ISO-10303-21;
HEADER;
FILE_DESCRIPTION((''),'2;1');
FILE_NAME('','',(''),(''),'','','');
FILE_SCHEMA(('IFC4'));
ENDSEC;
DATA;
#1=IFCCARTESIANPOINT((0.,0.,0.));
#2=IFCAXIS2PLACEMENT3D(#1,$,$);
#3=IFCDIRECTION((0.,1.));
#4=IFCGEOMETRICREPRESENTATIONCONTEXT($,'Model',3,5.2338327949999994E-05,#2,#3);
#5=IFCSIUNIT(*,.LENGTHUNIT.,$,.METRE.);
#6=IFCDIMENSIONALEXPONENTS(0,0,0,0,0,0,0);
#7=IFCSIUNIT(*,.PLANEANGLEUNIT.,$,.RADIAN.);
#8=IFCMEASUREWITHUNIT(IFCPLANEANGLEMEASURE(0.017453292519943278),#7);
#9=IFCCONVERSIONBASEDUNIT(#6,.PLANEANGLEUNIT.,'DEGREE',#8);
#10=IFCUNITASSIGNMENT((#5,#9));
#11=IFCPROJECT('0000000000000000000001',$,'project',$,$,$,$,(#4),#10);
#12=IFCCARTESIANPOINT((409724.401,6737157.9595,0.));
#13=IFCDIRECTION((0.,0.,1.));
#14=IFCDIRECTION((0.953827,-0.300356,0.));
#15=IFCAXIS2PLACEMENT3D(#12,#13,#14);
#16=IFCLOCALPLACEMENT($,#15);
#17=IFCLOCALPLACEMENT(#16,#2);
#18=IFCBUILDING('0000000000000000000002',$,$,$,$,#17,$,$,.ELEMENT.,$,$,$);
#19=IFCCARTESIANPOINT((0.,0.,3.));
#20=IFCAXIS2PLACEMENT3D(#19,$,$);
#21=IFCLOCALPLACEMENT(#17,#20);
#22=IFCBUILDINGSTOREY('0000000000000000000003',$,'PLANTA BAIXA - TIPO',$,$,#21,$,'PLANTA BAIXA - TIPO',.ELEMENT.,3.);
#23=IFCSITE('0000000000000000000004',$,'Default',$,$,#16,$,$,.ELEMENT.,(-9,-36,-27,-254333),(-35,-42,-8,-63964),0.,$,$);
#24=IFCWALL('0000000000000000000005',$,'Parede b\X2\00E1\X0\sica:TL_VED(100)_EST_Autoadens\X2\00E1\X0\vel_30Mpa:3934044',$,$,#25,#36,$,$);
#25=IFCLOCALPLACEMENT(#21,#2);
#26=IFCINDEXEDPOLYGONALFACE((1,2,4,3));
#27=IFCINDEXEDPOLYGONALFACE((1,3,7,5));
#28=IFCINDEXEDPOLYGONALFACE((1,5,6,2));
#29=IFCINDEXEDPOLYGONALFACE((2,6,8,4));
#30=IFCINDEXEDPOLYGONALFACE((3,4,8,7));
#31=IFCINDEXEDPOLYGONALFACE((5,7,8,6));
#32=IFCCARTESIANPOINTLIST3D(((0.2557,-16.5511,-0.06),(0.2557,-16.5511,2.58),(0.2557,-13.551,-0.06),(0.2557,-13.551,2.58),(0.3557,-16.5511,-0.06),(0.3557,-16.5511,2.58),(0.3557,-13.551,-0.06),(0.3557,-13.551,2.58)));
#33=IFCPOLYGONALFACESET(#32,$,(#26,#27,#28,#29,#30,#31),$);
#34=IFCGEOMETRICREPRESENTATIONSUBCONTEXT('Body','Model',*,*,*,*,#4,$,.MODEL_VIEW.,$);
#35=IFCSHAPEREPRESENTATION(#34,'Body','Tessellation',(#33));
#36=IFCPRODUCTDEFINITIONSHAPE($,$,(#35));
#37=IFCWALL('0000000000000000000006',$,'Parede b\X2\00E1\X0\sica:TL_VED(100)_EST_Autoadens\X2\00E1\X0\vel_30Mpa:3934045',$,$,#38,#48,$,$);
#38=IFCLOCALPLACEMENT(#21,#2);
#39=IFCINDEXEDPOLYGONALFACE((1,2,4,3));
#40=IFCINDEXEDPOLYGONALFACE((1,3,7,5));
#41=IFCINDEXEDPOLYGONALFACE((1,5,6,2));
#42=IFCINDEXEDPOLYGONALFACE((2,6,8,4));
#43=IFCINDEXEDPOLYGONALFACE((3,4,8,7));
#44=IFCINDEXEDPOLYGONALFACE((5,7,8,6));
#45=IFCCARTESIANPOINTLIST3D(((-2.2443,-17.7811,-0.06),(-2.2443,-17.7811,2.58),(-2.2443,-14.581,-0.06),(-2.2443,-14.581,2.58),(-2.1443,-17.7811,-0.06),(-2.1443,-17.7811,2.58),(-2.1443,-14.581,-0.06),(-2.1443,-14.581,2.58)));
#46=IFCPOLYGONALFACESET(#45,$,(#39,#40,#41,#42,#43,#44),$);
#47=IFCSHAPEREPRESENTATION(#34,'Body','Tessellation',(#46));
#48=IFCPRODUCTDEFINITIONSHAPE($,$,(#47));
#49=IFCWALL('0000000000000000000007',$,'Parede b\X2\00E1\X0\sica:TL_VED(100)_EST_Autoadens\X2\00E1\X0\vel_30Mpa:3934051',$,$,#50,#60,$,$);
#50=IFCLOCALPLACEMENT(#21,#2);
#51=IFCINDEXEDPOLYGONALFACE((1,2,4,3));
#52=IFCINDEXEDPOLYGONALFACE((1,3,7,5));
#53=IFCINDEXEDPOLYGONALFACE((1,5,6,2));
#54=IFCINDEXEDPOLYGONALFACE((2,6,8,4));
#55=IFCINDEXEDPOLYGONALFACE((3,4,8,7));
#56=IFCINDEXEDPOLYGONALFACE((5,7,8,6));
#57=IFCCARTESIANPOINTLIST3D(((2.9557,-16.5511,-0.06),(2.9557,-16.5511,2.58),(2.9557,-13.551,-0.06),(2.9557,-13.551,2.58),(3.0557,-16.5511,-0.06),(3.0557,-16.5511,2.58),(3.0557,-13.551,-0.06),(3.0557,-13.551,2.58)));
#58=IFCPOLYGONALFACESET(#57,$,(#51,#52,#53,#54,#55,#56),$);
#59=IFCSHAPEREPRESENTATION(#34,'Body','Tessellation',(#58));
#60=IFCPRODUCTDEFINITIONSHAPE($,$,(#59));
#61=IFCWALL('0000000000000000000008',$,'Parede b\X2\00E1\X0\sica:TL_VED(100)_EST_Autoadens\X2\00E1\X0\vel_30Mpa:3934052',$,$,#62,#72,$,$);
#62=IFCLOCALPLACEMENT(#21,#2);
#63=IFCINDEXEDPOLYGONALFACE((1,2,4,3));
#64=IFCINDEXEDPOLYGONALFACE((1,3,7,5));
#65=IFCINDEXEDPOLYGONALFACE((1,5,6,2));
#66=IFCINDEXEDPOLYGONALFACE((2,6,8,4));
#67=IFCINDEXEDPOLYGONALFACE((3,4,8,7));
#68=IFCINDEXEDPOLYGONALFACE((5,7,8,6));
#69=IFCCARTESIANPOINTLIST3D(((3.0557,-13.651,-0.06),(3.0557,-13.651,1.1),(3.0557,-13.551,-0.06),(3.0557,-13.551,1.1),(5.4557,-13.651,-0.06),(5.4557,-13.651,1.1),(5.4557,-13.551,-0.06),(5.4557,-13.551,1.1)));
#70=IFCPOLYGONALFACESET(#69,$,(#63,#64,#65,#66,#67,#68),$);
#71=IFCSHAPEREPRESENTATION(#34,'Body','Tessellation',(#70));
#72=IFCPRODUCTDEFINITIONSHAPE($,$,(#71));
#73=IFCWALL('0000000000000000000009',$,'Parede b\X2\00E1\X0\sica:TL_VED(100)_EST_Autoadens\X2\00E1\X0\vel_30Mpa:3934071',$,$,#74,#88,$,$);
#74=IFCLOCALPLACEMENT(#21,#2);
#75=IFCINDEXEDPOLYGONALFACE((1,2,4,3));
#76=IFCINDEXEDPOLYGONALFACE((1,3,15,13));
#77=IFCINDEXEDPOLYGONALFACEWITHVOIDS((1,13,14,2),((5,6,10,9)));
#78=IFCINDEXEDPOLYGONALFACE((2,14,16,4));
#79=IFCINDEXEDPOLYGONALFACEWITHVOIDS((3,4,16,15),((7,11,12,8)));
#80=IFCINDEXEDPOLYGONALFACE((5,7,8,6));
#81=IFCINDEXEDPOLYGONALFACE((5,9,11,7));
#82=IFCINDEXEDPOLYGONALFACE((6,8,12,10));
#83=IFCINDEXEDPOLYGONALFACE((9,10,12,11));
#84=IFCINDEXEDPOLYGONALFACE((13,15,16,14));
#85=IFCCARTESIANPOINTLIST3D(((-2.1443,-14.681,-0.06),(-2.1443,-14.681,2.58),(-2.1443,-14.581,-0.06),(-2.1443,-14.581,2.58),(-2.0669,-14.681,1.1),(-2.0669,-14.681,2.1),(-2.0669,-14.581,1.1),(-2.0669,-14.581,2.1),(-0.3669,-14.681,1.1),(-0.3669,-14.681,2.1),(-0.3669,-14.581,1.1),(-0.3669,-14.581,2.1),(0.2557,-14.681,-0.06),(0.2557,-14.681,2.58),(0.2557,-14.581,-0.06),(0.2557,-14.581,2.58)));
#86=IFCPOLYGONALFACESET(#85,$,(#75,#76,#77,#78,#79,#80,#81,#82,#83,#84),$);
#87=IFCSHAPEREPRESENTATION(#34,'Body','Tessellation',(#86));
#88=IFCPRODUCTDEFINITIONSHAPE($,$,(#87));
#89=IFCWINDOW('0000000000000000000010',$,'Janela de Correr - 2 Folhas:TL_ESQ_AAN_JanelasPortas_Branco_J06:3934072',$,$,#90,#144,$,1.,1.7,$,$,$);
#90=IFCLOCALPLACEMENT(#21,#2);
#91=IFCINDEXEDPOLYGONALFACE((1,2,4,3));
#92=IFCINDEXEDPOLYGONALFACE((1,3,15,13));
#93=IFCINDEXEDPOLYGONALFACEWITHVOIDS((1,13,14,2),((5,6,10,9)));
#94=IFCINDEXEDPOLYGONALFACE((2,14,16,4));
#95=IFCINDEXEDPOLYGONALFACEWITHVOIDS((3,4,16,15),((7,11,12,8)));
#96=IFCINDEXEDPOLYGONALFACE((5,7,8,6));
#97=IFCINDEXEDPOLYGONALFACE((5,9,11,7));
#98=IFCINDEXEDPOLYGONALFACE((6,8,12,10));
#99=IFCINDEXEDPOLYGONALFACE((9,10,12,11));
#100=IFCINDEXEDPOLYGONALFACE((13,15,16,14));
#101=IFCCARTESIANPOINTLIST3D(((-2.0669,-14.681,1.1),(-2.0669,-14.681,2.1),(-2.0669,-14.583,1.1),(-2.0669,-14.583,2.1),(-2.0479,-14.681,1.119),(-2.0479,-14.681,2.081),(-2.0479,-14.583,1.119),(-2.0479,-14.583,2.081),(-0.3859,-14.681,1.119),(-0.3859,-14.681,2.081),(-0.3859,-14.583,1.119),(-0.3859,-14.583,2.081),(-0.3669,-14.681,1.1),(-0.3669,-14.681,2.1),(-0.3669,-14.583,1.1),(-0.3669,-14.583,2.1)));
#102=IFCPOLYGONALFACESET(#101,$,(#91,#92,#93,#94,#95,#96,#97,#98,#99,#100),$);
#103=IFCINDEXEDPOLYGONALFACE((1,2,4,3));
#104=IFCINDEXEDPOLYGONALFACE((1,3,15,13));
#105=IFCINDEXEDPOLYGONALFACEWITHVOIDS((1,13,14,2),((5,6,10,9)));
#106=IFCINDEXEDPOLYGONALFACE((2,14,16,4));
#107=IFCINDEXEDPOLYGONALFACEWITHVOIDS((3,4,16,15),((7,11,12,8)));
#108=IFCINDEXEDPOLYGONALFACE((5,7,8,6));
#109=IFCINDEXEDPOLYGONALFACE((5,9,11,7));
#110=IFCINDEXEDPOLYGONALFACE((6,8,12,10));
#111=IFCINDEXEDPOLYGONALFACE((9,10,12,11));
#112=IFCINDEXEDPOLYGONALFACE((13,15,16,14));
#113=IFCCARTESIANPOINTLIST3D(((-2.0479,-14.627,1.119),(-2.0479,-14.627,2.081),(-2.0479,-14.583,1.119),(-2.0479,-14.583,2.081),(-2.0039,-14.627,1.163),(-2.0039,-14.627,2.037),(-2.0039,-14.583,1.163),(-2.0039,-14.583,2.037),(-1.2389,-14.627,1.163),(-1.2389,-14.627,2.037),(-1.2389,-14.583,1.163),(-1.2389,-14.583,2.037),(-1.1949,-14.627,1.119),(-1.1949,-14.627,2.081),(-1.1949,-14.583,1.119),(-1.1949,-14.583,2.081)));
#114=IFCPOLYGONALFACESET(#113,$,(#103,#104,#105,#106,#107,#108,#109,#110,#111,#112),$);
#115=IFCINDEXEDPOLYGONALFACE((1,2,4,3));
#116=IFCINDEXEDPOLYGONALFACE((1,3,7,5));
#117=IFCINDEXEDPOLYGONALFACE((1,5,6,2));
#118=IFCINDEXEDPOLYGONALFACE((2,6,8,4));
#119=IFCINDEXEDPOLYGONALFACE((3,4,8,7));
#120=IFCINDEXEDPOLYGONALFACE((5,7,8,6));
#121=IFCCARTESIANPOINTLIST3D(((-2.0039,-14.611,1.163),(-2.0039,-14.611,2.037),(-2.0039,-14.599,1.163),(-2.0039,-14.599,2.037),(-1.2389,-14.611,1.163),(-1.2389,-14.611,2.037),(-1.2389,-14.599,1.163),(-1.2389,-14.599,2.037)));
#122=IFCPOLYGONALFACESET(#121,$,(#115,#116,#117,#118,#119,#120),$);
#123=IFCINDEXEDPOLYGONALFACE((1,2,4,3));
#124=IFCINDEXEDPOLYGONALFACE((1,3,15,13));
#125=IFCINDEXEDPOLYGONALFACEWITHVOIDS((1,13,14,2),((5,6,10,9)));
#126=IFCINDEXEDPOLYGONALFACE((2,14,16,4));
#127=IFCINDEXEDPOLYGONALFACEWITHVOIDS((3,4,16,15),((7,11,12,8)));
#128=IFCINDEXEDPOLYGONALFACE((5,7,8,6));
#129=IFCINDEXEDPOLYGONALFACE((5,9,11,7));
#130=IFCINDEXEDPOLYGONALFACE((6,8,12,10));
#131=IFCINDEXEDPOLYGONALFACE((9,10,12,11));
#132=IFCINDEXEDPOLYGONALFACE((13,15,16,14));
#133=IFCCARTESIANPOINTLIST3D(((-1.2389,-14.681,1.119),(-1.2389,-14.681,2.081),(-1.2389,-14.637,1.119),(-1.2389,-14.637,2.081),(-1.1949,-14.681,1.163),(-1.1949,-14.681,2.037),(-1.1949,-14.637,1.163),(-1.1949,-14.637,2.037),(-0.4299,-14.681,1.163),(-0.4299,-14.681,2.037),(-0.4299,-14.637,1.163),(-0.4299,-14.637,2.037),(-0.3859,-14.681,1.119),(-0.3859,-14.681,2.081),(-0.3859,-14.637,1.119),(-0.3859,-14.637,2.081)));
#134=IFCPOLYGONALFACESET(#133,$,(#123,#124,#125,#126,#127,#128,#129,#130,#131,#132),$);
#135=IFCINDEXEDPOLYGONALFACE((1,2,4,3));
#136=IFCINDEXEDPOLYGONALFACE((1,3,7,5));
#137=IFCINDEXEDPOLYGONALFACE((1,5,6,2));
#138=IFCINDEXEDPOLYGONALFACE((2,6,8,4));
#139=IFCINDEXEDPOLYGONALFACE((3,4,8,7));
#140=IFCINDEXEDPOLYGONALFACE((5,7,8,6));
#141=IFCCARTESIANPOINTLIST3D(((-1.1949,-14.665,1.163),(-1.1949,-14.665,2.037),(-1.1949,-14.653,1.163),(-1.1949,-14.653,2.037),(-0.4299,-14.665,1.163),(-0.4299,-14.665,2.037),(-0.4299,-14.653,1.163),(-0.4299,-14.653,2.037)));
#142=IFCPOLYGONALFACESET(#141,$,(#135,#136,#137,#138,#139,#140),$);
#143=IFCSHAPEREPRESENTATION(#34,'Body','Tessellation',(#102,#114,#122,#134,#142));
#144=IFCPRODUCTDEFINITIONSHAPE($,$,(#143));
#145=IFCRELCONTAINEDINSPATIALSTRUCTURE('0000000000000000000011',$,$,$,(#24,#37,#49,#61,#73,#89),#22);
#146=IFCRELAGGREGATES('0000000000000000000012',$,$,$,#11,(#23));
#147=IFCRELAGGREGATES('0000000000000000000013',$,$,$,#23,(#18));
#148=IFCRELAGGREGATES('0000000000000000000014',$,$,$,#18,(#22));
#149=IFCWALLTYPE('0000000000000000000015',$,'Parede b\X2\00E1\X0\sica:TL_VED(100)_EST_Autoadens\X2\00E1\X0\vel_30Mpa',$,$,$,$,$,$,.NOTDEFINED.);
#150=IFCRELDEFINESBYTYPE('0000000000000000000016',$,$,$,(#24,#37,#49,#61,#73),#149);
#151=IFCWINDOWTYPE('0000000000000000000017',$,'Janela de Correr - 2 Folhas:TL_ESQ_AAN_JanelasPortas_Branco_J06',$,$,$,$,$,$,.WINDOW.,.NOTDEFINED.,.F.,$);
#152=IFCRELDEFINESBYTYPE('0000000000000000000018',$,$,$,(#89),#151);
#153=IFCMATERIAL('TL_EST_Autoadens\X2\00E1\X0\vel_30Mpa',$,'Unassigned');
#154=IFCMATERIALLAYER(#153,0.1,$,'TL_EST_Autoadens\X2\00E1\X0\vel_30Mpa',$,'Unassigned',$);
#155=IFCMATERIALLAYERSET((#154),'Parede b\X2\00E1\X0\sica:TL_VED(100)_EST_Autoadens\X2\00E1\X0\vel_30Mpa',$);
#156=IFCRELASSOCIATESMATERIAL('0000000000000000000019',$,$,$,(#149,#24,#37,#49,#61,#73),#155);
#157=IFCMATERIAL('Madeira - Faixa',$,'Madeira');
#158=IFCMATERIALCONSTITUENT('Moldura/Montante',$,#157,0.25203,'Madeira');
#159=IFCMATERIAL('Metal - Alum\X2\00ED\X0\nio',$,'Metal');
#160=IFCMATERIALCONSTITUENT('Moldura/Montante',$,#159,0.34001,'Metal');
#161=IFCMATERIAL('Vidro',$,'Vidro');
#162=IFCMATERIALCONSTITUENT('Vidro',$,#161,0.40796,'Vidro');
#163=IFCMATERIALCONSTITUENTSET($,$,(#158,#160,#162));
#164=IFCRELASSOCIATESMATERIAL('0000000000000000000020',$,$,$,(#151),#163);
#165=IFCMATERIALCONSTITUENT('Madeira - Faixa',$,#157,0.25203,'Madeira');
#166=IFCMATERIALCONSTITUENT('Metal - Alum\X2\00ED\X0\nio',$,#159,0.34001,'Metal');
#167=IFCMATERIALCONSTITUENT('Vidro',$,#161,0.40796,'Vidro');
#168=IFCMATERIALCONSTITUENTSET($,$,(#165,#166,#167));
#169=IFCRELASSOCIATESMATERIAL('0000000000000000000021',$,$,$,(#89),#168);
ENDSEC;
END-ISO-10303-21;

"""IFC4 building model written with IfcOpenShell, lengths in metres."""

from ifc_helpers import new_model, entity, si_unit, converted_unit, direction, frame, frame_2d, origin, origin_2d_with_axis, place, context, subcontext, project, spatial, polyline, rectangle, outline, extrude, source, transform, mapped, material, layer, layer_set, layer_usage, constituent, constituent_set, type_object, type_shapes, element, fill, save


model = new_model("IFC4")

# Units and contexts
model_context = context("Model", 3, precision=5.2338327949999994e-05, world=origin(), true_north=direction((0.0, 1.0)))
body_context = subcontext(model_context, "Body", "Model", "MODEL_VIEW")
ifc_project = project(units=[si_unit("LENGTHUNIT", "METRE"), converted_unit("PLANEANGLEUNIT", "DEGREE", entity("IfcPlaneAngleMeasure", 0.017453292519943278), si_unit("PLANEANGLEUNIT", "RADIAN"), dimensions=[0, 0, 0, 0, 0, 0, 0])], contexts=[model_context])

# Site, building, storey
site_placement = place(None, frame((409724.401, 6737157.9595, 0.0), z_axis=(0.0, 0.0, 1.0), x_axis=(0.953827, -0.300356, 0.0)))
site = spatial("IfcSite", under=ifc_project, at=site_placement, Name="Default", CompositionType="ELEMENT", RefLatitude=(-9, -36, -27, -254333), RefLongitude=(-35, -42, -8, -63964), RefElevation=0.0)
building_placement = place(site_placement, origin())
building = spatial("IfcBuilding", under=site, at=building_placement, CompositionType="ELEMENT")
storey_placement = place(building_placement, frame((0.0, 0.0, 3.0)))
storey = spatial("IfcBuildingStorey", under=building, at=storey_placement, Name="PLANTA BAIXA - TIPO", LongName="PLANTA BAIXA - TIPO", CompositionType="ELEMENT", Elevation=3.0)

# Walls
ifc_material_1 = material(Name="TL_EST_Autoadensável_30Mpa", Category="Unassigned")
ifc_layer_1 = layer(ifc_material_1, 0.1, Name="TL_EST_Autoadensável_30Mpa", Category="Unassigned")
ifc_layer_set_1 = layer_set([ifc_layer_1], Name="Parede básica:TL_VED(100)_EST_Autoadensável_30Mpa")
ifc_layer_usage_1 = layer_usage(ifc_layer_set_1, "AXIS2", "NEGATIVE", 0.05)
wall_type_1 = type_object("IfcWallType", Name="Parede básica:TL_VED(100)_EST_Autoadensável_30Mpa", PredefinedType="NOTDEFINED", material=ifc_layer_set_1)
wall_1_placement = place(storey_placement, frame((0.3057, -13.551, -0.06), z_axis=(0.0, 0.0, 1.0), x_axis=(0.0, -1.0, 0.0)))
element("IfcWall", 1, at=wall_1_placement, inside=storey, type_object=wall_type_1, material=ifc_layer_usage_1, Name="Parede básica:TL_VED(100)_EST_Autoadensável_30Mpa:3934044", context=body_context, shape_type="SweptSolid", body=[
    extrude(rectangle(XDim=3.0001, YDim=0.1, at=frame_2d((1.5001, 0.0), x_axis=(-1.0, 0.0))), origin(), (0.0, 0.0, 1.0), 2.64),
])
ifc_layer_usage_2 = layer_usage(ifc_layer_set_1, "AXIS2", "NEGATIVE", 0.05)
wall_2_placement = place(storey_placement, frame((-2.1943, -14.581, -0.06), z_axis=(0.0, 0.0, 1.0), x_axis=(0.0, -1.0, 0.0)))
element("IfcWall", 2, at=wall_2_placement, inside=storey, type_object=wall_type_1, material=ifc_layer_usage_2, Name="Parede básica:TL_VED(100)_EST_Autoadensável_30Mpa:3934045", context=body_context, shape_type="SweptSolid", body=[
    extrude(rectangle(XDim=3.2001, YDim=0.1, at=frame_2d((1.6001, 0.0), x_axis=(-1.0, 0.0))), origin(), (0.0, 0.0, 1.0), 2.64),
])

# Wall, opening
ifc_layer_usage_3 = layer_usage(ifc_layer_set_1, "AXIS2", "NEGATIVE", 0.05)
wall_3_placement = place(storey_placement, frame((3.0057, -13.551, -0.06), z_axis=(0.0, 0.0, 1.0), x_axis=(0.0, -1.0, 0.0)))
wall_3 = element("IfcWall", 3, at=wall_3_placement, inside=storey, type_object=wall_type_1, material=ifc_layer_usage_3, Name="Parede básica:TL_VED(100)_EST_Autoadensável_30Mpa:3934051", context=body_context, shape_type="SweptSolid", body=[
    extrude(rectangle(XDim=3.0001, YDim=0.1, at=frame_2d((1.5001, 0.0), x_axis=(-1.0, 0.0))), origin(), (0.0, 0.0, 1.0), 2.64),
])
opening_1_placement = place(wall_3_placement, frame((-13.551, -3.0057, 0.06)))
element("IfcOpeningElement", 4, at=opening_1_placement, cuts=wall_3, PredefinedType="OPENING", context=body_context, shape_type="SweptSolid", body=[
    extrude(rectangle(XDim=2.1, YDim=0.1, at=frame_2d((0.0, 0.0), x_axis=(0.0, 1.0))), frame((14.501, 3.0557, 1.05), z_axis=(0.0, 1.0, 0.0), x_axis=(1.0, 0.0, 0.0)), (0.0, 0.0, 1.0), 2.4),
])

# Wall
ifc_layer_usage_4 = layer_usage(ifc_layer_set_1, "AXIS2", "NEGATIVE", 0.05)
wall_4_placement = place(storey_placement, frame((3.0557, -13.601, -0.06)))
element("IfcWall", 5, at=wall_4_placement, inside=storey, type_object=wall_type_1, material=ifc_layer_usage_4, Name="Parede básica:TL_VED(100)_EST_Autoadensável_30Mpa:3934052", context=body_context, shape_type="SweptSolid", body=[
    extrude(rectangle(XDim=2.4, YDim=0.1, at=frame_2d((1.2, 0.0), x_axis=(-1.0, 0.0))), origin(), (0.0, 0.0, 1.0), 1.16),
])

# Wall, opening, window
ifc_layer_usage_5 = layer_usage(ifc_layer_set_1, "AXIS2", "NEGATIVE", 0.05)
wall_5_placement = place(storey_placement, frame((-2.1443, -14.631, -0.06)))
wall_5 = element("IfcWall", 6, at=wall_5_placement, inside=storey, type_object=wall_type_1, material=ifc_layer_usage_5, Name="Parede básica:TL_VED(100)_EST_Autoadensável_30Mpa:3934071", context=body_context, shape_type="SweptSolid", body=[
    extrude(rectangle(XDim=2.4, YDim=0.1, at=frame_2d((1.2, 0.0), x_axis=(-1.0, 0.0))), origin(), (0.0, 0.0, 1.0), 2.64),
])
opening_2_placement = place(wall_5_placement, frame((0.0774, -0.05, 1.16)))
opening_2 = element("IfcOpeningElement", 7, at=opening_2_placement, cuts=wall_5, PredefinedType="OPENING", context=body_context, shape_type="SweptSolid", body=[
    extrude(rectangle(XDim=1.0, YDim=1.7, at=frame_2d((0.5, 0.85), x_axis=(-1.0, 0.0))), frame((0.0, 0.0, 0.0), z_axis=(0.0, 1.0, 0.0), x_axis=(0.0, 0.0, 1.0)), (0.0, 0.0, 1.0), 0.1),
])
ifc_material_2 = material(Name="Madeira - Faixa", Category="Madeira")
ifc_constituent_1 = constituent(ifc_material_2, Name="Madeira - Faixa", Category="Madeira", fraction=0.25203)
ifc_material_3 = material(Name="Metal - Alumínio", Category="Metal")
ifc_constituent_2 = constituent(ifc_material_3, Name="Metal - Alumínio", Category="Metal", fraction=0.34001)
ifc_material_4 = material(Name="Vidro", Category="Vidro")
ifc_constituent_3 = constituent(ifc_material_4, Name="Vidro", Category="Vidro", fraction=0.40796)
ifc_constituent_set_1 = constituent_set(constituents=[ifc_constituent_1, ifc_constituent_2, ifc_constituent_3])
ifc_constituent_4 = constituent(ifc_material_2, Name="Moldura/Montante", Category="Madeira", fraction=0.25203)
ifc_constituent_5 = constituent(ifc_material_3, Name="Moldura/Montante", Category="Metal", fraction=0.34001)
ifc_constituent_6 = constituent(ifc_material_4, Name="Vidro", Category="Vidro", fraction=0.40796)
ifc_constituent_set_2 = constituent_set(constituents=[ifc_constituent_4, ifc_constituent_5, ifc_constituent_6])
window_type_1 = type_object("IfcWindowType", Name="Janela de Correr - 2 Folhas:TL_ESQ_AAN_JanelasPortas_Branco_J06", ParameterTakesPrecedence=False, PartitioningType="NOTDEFINED", PredefinedType="WINDOW", material=ifc_constituent_set_2)
shared_shape_1 = source(origin(), body_context, "Body", "SweptSolid", [
    extrude(outline(polyline([(-0.85, -0.5), (0.85, -0.5), (0.85, 0.5), (-0.85, 0.5), (-0.85, -0.5)]), holes=[polyline([(-0.831, -0.481), (-0.831, 0.481), (0.831, 0.481), (0.831, -0.481), (-0.831, -0.481)])]), frame((0.85, 0.124, 0.5), z_axis=(0.0, -1.0, 0.0), x_axis=(-1.0, 0.0, 0.0)), (0.0, 0.0, 1.0), 0.098),
    extrude(outline(polyline([(-0.4265, -0.481), (0.4265, -0.481), (0.4265, 0.481), (-0.4265, 0.481), (-0.4265, -0.481)]), holes=[polyline([(-0.3825, -0.437), (-0.3825, 0.437), (0.3825, 0.437), (0.3825, -0.437), (-0.3825, -0.437)])]), frame((0.4455, 0.124, 0.5), z_axis=(0.0, -1.0, 0.0), x_axis=(-1.0, 0.0, 0.0)), (0.0, 0.0, 1.0), 0.044),
    extrude(rectangle(XDim=0.765, YDim=0.012, at=origin_2d_with_axis()), frame((0.4455, 0.102, 0.063), z_axis=(0.0, 0.0, 1.0), x_axis=(-1.0, 0.0, 0.0)), (0.0, 0.0, 1.0), 0.874),
    extrude(outline(polyline([(-0.481, -0.4265), (0.481, -0.4265), (0.481, 0.4265), (-0.481, 0.4265), (-0.481, -0.4265)]), holes=[polyline([(-0.437, -0.3825), (-0.437, 0.3825), (0.437, 0.3825), (0.437, -0.3825), (-0.437, -0.3825)])]), frame((1.2545, 0.07, 0.5), z_axis=(0.0, -1.0, 0.0), x_axis=(0.0, 0.0, -1.0)), (0.0, 0.0, 1.0), 0.044),
    extrude(rectangle(XDim=0.765, YDim=0.012, at=origin_2d_with_axis()), frame((1.2545, 0.048, 0.063), z_axis=(0.0, 0.0, 1.0), x_axis=(-1.0, 0.0, 0.0)), (0.0, 0.0, 1.0), 0.874),
])
type_shapes(window_type_1, [shared_shape_1])
window_1_placement = place(opening_2_placement, frame((0.0, -0.026, 0.0)))
window_1 = element("IfcWindow", 8, at=window_1_placement, inside=storey, type_object=window_type_1, material=ifc_constituent_set_1, Name="Janela de Correr - 2 Folhas:TL_ESQ_AAN_JanelasPortas_Branco_J06:3934072", OverallHeight=1.0, OverallWidth=1.7, context=body_context, shape_type="MappedRepresentation", body=[
    mapped(shared_shape_1, transform((0.0, 0.0, 0.0), scale=1.0)),
])
fill(opening_2, window_1)

save(model, "model.ifc")
